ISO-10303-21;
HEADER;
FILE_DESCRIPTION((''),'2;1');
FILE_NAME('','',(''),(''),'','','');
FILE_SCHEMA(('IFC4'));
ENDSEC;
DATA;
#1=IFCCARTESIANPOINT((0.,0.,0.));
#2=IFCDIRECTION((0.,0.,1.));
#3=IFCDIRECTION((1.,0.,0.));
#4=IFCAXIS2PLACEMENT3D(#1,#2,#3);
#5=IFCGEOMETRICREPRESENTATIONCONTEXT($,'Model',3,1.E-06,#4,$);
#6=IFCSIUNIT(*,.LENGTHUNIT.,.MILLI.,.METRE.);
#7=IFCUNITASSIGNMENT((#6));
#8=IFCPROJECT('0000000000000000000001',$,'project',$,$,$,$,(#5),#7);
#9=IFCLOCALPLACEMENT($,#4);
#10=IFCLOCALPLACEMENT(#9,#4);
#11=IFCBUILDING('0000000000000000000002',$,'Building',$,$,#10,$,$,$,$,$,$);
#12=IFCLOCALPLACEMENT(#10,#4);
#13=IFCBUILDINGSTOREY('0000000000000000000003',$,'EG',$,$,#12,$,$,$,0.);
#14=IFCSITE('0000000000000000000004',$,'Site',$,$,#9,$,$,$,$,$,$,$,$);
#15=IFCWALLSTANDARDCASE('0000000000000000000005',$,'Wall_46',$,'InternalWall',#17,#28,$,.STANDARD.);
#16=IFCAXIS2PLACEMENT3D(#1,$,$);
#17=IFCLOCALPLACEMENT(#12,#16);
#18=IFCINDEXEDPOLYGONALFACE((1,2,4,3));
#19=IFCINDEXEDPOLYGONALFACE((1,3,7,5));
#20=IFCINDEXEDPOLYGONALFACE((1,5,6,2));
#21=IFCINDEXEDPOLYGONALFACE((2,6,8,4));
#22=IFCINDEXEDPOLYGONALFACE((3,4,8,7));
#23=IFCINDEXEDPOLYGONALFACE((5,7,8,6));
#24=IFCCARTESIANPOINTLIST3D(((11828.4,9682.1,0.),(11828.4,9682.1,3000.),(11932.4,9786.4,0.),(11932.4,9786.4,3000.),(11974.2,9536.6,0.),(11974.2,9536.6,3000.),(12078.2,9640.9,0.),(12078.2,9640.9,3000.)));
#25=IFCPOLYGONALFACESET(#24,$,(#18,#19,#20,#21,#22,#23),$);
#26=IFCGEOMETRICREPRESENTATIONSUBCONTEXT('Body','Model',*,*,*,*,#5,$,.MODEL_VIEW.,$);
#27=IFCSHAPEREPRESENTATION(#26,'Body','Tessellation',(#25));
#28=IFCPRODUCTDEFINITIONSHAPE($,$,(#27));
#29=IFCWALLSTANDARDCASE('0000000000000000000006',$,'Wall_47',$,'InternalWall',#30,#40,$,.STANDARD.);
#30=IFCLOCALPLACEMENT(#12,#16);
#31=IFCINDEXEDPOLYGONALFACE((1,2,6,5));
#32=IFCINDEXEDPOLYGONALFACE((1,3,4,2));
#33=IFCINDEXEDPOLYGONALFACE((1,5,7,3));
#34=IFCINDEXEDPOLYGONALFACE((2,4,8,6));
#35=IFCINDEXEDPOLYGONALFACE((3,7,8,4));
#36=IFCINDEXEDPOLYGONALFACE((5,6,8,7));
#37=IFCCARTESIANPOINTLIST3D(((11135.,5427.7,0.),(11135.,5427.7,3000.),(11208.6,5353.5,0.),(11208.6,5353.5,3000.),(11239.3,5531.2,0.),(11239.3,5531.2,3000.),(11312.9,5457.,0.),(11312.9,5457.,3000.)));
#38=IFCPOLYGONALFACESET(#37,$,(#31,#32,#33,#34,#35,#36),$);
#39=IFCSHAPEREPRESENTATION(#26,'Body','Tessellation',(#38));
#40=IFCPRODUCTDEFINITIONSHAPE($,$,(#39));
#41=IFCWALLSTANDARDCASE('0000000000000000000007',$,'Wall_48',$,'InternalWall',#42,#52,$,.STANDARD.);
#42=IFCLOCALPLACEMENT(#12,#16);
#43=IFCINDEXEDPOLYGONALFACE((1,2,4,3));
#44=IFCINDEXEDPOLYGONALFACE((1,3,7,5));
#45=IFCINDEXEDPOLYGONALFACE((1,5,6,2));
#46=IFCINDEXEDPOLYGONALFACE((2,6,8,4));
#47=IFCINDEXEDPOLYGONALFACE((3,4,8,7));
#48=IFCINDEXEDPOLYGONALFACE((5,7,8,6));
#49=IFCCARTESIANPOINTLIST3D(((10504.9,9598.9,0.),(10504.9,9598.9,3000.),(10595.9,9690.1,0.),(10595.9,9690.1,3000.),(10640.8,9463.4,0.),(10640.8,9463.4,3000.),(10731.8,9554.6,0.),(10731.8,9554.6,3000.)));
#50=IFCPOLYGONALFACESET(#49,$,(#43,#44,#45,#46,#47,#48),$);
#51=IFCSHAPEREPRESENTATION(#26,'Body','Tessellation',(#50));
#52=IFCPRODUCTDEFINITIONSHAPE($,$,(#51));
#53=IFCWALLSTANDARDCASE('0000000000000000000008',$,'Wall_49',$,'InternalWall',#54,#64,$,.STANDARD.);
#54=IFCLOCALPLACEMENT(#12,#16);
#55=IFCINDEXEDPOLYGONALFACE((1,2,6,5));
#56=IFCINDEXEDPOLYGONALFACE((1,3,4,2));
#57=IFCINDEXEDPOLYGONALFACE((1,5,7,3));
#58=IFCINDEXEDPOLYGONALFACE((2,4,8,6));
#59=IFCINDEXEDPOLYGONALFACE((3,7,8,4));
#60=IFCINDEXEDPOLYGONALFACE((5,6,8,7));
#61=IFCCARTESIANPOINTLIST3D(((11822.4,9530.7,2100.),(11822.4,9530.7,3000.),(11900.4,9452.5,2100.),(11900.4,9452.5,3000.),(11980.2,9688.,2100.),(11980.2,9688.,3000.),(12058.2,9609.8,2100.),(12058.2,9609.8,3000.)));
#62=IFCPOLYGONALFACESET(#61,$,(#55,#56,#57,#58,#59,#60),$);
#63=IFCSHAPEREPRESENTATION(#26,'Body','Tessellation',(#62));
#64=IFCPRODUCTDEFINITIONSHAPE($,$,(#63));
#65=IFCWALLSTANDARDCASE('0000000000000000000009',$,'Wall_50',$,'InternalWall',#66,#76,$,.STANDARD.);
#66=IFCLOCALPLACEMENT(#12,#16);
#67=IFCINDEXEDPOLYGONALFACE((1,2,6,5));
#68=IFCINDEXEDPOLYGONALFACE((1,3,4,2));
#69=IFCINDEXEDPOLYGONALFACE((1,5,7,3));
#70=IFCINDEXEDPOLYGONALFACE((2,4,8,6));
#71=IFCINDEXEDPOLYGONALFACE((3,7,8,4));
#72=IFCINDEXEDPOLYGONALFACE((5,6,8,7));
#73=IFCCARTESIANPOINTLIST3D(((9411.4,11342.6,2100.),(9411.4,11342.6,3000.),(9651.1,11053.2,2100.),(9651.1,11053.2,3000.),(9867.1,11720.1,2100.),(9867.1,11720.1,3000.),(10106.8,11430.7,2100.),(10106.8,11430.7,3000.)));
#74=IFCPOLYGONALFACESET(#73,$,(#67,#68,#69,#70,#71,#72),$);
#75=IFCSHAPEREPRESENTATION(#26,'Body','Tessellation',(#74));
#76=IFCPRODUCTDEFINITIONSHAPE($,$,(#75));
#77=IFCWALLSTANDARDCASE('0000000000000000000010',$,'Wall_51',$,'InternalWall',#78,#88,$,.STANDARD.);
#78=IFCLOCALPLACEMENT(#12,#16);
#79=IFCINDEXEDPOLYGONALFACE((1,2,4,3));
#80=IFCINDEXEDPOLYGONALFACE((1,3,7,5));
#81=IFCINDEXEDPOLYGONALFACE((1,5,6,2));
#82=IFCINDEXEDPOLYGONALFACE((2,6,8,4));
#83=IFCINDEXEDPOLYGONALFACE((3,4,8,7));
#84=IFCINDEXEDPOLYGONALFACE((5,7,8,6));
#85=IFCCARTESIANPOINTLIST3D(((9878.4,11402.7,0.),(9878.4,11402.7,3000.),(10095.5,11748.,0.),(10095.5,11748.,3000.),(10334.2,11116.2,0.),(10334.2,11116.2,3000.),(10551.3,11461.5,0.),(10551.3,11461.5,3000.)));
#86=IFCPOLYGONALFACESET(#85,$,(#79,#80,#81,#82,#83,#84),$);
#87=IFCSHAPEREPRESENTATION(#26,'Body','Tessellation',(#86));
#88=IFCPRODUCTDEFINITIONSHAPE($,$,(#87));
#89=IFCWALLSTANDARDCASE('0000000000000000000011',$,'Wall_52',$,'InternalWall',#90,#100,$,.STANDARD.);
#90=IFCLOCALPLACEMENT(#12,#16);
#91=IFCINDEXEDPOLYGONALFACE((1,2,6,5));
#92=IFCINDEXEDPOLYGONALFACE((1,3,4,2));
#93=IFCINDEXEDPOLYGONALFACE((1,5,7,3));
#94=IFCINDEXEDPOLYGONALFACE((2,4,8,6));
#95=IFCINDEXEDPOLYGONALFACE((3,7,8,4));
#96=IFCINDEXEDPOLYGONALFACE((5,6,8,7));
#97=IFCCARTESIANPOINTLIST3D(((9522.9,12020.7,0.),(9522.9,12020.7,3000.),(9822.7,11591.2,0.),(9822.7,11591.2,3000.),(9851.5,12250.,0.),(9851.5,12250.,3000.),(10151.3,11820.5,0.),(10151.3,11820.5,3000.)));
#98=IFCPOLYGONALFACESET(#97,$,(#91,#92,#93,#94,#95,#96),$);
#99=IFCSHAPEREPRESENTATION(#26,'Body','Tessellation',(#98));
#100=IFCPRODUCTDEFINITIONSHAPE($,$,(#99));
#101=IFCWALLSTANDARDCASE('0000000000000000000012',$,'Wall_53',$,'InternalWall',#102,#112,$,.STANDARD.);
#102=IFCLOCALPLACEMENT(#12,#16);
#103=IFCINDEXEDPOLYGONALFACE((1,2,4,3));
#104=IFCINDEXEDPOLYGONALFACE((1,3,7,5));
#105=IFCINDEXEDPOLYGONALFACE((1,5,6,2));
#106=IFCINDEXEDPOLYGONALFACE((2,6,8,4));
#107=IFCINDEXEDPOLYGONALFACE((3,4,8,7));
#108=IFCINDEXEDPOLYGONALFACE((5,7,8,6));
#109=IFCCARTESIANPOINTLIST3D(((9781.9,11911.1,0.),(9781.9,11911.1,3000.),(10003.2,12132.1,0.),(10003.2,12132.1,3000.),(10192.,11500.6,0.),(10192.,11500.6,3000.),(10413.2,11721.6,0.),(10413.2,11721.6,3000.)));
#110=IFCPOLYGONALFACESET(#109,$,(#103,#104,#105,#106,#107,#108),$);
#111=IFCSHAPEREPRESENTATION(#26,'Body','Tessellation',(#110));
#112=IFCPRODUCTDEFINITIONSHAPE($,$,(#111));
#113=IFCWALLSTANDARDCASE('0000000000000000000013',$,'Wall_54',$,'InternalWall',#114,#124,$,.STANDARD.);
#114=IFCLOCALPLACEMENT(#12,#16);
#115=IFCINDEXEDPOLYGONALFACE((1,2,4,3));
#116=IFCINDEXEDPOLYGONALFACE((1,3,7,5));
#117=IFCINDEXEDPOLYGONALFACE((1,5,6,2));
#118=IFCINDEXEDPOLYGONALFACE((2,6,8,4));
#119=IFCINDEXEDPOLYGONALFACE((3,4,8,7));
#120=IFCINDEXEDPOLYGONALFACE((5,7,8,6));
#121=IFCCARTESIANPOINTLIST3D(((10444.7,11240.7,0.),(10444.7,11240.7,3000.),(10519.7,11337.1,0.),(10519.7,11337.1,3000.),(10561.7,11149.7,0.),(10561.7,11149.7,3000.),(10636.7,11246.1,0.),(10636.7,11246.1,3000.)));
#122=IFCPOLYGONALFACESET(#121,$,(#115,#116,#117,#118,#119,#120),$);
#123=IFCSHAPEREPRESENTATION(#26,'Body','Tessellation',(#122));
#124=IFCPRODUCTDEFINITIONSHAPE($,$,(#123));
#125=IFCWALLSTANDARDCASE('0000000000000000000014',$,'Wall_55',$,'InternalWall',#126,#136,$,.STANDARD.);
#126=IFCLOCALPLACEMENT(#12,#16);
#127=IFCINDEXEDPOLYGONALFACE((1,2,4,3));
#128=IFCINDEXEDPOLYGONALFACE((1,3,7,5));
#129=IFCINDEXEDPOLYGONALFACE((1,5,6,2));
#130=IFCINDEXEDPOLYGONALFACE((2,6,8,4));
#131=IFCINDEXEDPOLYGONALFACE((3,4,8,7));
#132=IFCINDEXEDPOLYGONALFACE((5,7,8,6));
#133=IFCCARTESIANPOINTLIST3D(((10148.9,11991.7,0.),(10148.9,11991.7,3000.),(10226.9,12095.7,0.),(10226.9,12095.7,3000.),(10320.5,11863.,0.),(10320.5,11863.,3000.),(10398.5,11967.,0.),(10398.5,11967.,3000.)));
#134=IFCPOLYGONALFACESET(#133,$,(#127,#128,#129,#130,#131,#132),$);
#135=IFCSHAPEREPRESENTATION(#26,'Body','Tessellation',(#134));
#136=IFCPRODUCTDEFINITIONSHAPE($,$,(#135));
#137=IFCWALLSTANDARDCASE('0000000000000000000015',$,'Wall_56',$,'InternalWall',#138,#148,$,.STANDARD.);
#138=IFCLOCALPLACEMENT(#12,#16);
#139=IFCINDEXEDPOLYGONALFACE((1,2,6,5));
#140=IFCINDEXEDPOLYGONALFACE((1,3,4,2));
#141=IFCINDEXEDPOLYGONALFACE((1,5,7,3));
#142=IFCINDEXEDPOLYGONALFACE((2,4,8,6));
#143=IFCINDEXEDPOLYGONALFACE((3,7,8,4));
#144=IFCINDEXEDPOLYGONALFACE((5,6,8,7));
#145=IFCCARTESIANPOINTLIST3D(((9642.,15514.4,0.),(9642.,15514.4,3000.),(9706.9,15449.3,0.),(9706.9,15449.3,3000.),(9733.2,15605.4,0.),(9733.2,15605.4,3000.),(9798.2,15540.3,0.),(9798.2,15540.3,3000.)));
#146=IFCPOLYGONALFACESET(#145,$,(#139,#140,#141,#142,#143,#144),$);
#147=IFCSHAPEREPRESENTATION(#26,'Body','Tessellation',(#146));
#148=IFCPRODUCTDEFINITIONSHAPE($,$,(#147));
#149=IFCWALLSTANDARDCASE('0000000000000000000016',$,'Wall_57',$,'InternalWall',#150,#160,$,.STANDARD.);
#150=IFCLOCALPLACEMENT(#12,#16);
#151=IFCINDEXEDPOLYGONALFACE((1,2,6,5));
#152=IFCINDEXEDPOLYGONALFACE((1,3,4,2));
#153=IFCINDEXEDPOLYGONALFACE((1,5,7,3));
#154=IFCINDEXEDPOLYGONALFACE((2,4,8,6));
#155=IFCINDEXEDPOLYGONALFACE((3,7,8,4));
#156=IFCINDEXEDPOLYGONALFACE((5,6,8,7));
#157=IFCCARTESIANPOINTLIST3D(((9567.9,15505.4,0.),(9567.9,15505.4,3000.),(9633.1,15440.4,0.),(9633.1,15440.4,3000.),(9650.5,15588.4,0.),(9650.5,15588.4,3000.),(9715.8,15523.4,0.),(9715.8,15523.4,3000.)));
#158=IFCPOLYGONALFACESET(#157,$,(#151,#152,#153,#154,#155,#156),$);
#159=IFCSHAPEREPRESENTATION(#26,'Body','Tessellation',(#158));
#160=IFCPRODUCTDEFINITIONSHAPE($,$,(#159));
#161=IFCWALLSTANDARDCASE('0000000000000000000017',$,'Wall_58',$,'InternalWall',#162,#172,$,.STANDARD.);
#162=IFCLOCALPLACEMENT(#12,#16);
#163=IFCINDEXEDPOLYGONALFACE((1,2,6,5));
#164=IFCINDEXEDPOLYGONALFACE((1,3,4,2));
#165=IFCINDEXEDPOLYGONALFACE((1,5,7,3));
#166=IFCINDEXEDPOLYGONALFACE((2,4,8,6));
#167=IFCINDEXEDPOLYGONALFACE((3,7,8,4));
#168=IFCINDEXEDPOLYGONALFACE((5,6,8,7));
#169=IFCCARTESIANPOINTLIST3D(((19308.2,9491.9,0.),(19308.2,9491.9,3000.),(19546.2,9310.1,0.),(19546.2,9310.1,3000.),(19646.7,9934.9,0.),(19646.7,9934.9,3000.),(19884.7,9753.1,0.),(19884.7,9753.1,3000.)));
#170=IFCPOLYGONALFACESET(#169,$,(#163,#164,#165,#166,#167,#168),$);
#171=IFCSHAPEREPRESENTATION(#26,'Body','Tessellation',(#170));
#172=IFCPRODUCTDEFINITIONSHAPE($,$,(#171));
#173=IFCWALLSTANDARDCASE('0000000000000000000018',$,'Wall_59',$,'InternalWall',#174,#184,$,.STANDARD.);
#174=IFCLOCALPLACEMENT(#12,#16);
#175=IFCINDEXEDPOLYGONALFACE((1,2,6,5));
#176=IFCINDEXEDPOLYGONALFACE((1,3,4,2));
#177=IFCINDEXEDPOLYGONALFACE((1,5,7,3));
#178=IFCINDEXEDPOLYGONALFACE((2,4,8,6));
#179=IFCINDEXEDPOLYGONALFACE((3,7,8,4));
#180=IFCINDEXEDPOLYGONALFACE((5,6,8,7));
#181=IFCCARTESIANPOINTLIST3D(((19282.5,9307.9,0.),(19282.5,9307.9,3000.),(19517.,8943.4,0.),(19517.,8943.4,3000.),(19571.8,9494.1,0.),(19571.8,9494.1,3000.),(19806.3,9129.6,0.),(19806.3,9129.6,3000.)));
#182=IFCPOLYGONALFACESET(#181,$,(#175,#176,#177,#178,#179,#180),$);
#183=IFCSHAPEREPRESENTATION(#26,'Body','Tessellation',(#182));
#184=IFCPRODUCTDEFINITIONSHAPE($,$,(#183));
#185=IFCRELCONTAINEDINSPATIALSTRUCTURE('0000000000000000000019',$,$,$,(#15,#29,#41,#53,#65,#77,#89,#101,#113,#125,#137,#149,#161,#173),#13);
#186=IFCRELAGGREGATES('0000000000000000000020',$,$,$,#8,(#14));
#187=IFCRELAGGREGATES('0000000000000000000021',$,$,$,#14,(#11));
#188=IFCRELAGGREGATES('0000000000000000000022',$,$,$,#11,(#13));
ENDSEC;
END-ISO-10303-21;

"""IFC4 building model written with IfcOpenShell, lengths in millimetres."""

from ifc_helpers import new_model, si_unit, frame, origin_with_axes, place, context, subcontext, project, spatial, rectangle, extrude, element, save


model = new_model("IFC4")

# Units and contexts
model_context = context("Model", 3, precision=1e-06, world=origin_with_axes())
body_context = subcontext(model_context, "Body", "Model", "MODEL_VIEW")
ifc_project = project(units=[si_unit("LENGTHUNIT", "METRE", prefix="MILLI")], contexts=[model_context])

# Site, building, storey
site_placement = place(None, origin_with_axes())
site = spatial("IfcSite", under=ifc_project, at=site_placement, Name="Site")
building_placement = place(site_placement, origin_with_axes())
building = spatial("IfcBuilding", under=site, at=building_placement, Name="Building")
storey_placement = place(building_placement, origin_with_axes())
storey = spatial("IfcBuildingStorey", under=building, at=storey_placement, Name="EG", Elevation=0.0)

# Walls
wall_1_placement = place(storey_placement, origin_with_axes())
element("IfcWallStandardCase", 1, at=wall_1_placement, inside=storey, Name="Wall_46", ObjectType="InternalWall", PredefinedType="STANDARD", context=body_context, shape_type="SweptSolid", body=[
    extrude(rectangle(XDim=147.3, YDim=206.0), frame((11953.3, 9661.5, 0.0), z_axis=(0.0, 0.0, 1.0), x_axis=(0.706257, 0.707955, 0.0)), (0.0, 0.0, 1.0), 3000.0),
])
wall_2_placement = place(storey_placement, origin_with_axes())
element("IfcWallStandardCase", 2, at=wall_2_placement, inside=storey, Name="Wall_47", ObjectType="InternalWall", PredefinedType="STANDARD", context=body_context, shape_type="SweptSolid", body=[
    extrude(rectangle(XDim=146.9, YDim=104.5), frame((11224.0, 5442.4, 0.0), z_axis=(0.0, 0.0, 1.0), x_axis=(-0.709655, -0.704549, 0.0)), (0.0, 0.0, 1.0), 3000.0),
])
wall_3_placement = place(storey_placement, origin_with_axes())
element("IfcWallStandardCase", 3, at=wall_3_placement, inside=storey, Name="Wall_48", ObjectType="InternalWall", PredefinedType="STANDARD", context=body_context, shape_type="SweptSolid", body=[
    extrude(rectangle(XDim=128.9, YDim=191.9), frame((10618.3, 9576.8, 0.0), z_axis=(0.0, 0.0, 1.0), x_axis=(-0.706136, -0.708076, 0.0)), (0.0, 0.0, 1.0), 3000.0),
])

# Walls, openings
wall_4_placement = place(storey_placement, origin_with_axes())
wall_4 = element("IfcWallStandardCase", 4, at=wall_4_placement, inside=storey, Name="Wall_49", ObjectType="InternalWall", PredefinedType="STANDARD", context=body_context, shape_type="SweptSolid", body=[
    extrude(rectangle(XDim=110.5, YDim=222.8), frame((11940.3, 9570.3, 0.0), z_axis=(0.0, 0.0, 1.0), x_axis=(0.705975, -0.708237, 0.0)), (0.0, 0.0, 1.0), 3000.0),
])
opening_1_placement = place(wall_4_placement, origin_with_axes())
element("IfcOpeningElement", 5, at=opening_1_placement, inside=storey, cuts=wall_4, context=body_context, shape_type="SweptSolid", body=[
    extrude(rectangle(XDim=450.0, YDim=222.8), frame((11946.6, 9563.9, 0.0), z_axis=(0.0, 0.0, 1.0), x_axis=(0.705975, -0.708237, 0.0)), (0.0, 0.0, 1.0), 2100.0),
])
wall_5_placement = place(storey_placement, origin_with_axes())
wall_5 = element("IfcWallStandardCase", 6, at=wall_5_placement, inside=storey, Name="Wall_50", ObjectType="InternalWall", PredefinedType="STANDARD", context=body_context, shape_type="SweptSolid", body=[
    extrude(rectangle(XDim=591.8, YDim=375.8), frame((9759.1, 11386.6, 0.0), z_axis=(0.0, 0.0, 1.0), x_axis=(-0.770122, -0.637896, 0.0)), (0.0, 0.0, 1.0), 3000.0),
])
opening_2_placement = place(wall_5_placement, origin_with_axes())
element("IfcOpeningElement", 7, at=opening_2_placement, inside=storey, cuts=wall_5, context=body_context, shape_type="SweptSolid", body=[
    extrude(rectangle(XDim=591.8, YDim=375.8), frame((9759.1, 11386.6, 0.0), z_axis=(0.0, 0.0, 1.0), x_axis=(-0.770122, -0.637896, 0.0)), (0.0, 0.0, 1.0), 2100.0),
])

# Walls
wall_6_placement = place(storey_placement, origin_with_axes())
element("IfcWallStandardCase", 8, at=wall_6_placement, inside=storey, Name="Wall_51", ObjectType="InternalWall", PredefinedType="STANDARD", context=body_context, shape_type="SweptSolid", body=[
    extrude(rectangle(XDim=538.3, YDim=407.9), frame((10214.8, 11432.1, 0.0), z_axis=(0.0, 0.0, 1.0), x_axis=(0.846613, -0.53221, 0.0)), (0.0, 0.0, 1.0), 3000.0),
])
wall_7_placement = place(storey_placement, origin_with_axes())
element("IfcWallStandardCase", 9, at=wall_7_placement, inside=storey, Name="Wall_52", ObjectType="InternalWall", PredefinedType="STANDARD", context=body_context, shape_type="SweptSolid", body=[
    extrude(rectangle(XDim=523.8, YDim=400.7), frame((9837.1, 11920.6, 0.0), z_axis=(0.0, 0.0, 1.0), x_axis=(0.572309, -0.820038, 0.0)), (0.0, 0.0, 1.0), 3000.0),
])
wall_8_placement = place(storey_placement, origin_with_axes())
element("IfcWallStandardCase", 10, at=wall_8_placement, inside=storey, Name="Wall_53", ObjectType="InternalWall", PredefinedType="STANDARD", context=body_context, shape_type="SweptSolid", body=[
    extrude(rectangle(XDim=312.7, YDim=580.2), frame((10097.6, 11816.4, 0.0), z_axis=(0.0, 0.0, 1.0), x_axis=(0.707506, 0.706707, 0.0)), (0.0, 0.0, 1.0), 3000.0),
])
wall_9_placement = place(storey_placement, origin_with_axes())
element("IfcWallStandardCase", 11, at=wall_9_placement, inside=storey, Name="Wall_54", ObjectType="InternalWall", PredefinedType="STANDARD", context=body_context, shape_type="SweptSolid", body=[
    extrude(rectangle(XDim=148.2, YDim=122.1), frame((10540.7, 11243.4, 0.0), z_axis=(0.0, 0.0, 1.0), x_axis=(0.789352, -0.613941, 0.0)), (0.0, 0.0, 1.0), 3000.0),
])
wall_10_placement = place(storey_placement, origin_with_axes())
element("IfcWallStandardCase", 12, at=wall_10_placement, inside=storey, Name="Wall_55", ObjectType="InternalWall", PredefinedType="STANDARD", context=body_context, shape_type="SweptSolid", body=[
    extrude(rectangle(XDim=130.0, YDim=214.6), frame((10273.7, 11979.4, 0.0), z_axis=(0.0, 0.0, 1.0), x_axis=(-0.6, -0.8, 0.0)), (0.0, 0.0, 1.0), 3000.0),
])
wall_11_placement = place(storey_placement, origin_with_axes())
element("IfcWallStandardCase", 13, at=wall_11_placement, inside=storey, Name="Wall_56", ObjectType="InternalWall", PredefinedType="STANDARD", context=body_context, shape_type="SweptSolid", body=[
    extrude(rectangle(XDim=128.9, YDim=92.0), frame((9720.1, 15527.4, 0.0), z_axis=(0.0, 0.0, 1.0), x_axis=(0.708076, 0.706136, 0.0)), (0.0, 0.0, 1.0), 3000.0),
])
wall_12_placement = place(storey_placement, origin_with_axes())
element("IfcWallStandardCase", 14, at=wall_12_placement, inside=storey, Name="Wall_57", ObjectType="InternalWall", PredefinedType="STANDARD", context=body_context, shape_type="SweptSolid", body=[
    extrude(rectangle(XDim=92.1, YDim=117.1), frame((9641.8, 15514.4, 0.0), z_axis=(0.0, 0.0, 1.0), x_axis=(-0.708463, 0.705748, 0.0)), (0.0, 0.0, 1.0), 3000.0),
])
wall_13_placement = place(storey_placement, origin_with_axes())
element("IfcWallStandardCase", 15, at=wall_13_placement, inside=storey, Name="Wall_58", ObjectType="InternalWall", PredefinedType="STANDARD", context=body_context, shape_type="SweptSolid", body=[
    extrude(rectangle(XDim=557.5, YDim=299.5), frame((19596.4, 9622.5, 0.0), z_axis=(0.0, 0.0, 1.0), x_axis=(0.60715, 0.794587, 0.0)), (0.0, 0.0, 1.0), 3000.0),
])
wall_14_placement = place(storey_placement, origin_with_axes())
element("IfcWallStandardCase", 16, at=wall_14_placement, inside=storey, Name="Wall_59", ObjectType="InternalWall", PredefinedType="STANDARD", context=body_context, shape_type="SweptSolid", body=[
    extrude(rectangle(XDim=433.4, YDim=344.0), frame((19544.4, 9218.8, 0.0), z_axis=(0.0, 0.0, 1.0), x_axis=(-0.541049, 0.840991, 0.0)), (0.0, 0.0, 1.0), 3000.0),
])

save(model, "model.ifc")
